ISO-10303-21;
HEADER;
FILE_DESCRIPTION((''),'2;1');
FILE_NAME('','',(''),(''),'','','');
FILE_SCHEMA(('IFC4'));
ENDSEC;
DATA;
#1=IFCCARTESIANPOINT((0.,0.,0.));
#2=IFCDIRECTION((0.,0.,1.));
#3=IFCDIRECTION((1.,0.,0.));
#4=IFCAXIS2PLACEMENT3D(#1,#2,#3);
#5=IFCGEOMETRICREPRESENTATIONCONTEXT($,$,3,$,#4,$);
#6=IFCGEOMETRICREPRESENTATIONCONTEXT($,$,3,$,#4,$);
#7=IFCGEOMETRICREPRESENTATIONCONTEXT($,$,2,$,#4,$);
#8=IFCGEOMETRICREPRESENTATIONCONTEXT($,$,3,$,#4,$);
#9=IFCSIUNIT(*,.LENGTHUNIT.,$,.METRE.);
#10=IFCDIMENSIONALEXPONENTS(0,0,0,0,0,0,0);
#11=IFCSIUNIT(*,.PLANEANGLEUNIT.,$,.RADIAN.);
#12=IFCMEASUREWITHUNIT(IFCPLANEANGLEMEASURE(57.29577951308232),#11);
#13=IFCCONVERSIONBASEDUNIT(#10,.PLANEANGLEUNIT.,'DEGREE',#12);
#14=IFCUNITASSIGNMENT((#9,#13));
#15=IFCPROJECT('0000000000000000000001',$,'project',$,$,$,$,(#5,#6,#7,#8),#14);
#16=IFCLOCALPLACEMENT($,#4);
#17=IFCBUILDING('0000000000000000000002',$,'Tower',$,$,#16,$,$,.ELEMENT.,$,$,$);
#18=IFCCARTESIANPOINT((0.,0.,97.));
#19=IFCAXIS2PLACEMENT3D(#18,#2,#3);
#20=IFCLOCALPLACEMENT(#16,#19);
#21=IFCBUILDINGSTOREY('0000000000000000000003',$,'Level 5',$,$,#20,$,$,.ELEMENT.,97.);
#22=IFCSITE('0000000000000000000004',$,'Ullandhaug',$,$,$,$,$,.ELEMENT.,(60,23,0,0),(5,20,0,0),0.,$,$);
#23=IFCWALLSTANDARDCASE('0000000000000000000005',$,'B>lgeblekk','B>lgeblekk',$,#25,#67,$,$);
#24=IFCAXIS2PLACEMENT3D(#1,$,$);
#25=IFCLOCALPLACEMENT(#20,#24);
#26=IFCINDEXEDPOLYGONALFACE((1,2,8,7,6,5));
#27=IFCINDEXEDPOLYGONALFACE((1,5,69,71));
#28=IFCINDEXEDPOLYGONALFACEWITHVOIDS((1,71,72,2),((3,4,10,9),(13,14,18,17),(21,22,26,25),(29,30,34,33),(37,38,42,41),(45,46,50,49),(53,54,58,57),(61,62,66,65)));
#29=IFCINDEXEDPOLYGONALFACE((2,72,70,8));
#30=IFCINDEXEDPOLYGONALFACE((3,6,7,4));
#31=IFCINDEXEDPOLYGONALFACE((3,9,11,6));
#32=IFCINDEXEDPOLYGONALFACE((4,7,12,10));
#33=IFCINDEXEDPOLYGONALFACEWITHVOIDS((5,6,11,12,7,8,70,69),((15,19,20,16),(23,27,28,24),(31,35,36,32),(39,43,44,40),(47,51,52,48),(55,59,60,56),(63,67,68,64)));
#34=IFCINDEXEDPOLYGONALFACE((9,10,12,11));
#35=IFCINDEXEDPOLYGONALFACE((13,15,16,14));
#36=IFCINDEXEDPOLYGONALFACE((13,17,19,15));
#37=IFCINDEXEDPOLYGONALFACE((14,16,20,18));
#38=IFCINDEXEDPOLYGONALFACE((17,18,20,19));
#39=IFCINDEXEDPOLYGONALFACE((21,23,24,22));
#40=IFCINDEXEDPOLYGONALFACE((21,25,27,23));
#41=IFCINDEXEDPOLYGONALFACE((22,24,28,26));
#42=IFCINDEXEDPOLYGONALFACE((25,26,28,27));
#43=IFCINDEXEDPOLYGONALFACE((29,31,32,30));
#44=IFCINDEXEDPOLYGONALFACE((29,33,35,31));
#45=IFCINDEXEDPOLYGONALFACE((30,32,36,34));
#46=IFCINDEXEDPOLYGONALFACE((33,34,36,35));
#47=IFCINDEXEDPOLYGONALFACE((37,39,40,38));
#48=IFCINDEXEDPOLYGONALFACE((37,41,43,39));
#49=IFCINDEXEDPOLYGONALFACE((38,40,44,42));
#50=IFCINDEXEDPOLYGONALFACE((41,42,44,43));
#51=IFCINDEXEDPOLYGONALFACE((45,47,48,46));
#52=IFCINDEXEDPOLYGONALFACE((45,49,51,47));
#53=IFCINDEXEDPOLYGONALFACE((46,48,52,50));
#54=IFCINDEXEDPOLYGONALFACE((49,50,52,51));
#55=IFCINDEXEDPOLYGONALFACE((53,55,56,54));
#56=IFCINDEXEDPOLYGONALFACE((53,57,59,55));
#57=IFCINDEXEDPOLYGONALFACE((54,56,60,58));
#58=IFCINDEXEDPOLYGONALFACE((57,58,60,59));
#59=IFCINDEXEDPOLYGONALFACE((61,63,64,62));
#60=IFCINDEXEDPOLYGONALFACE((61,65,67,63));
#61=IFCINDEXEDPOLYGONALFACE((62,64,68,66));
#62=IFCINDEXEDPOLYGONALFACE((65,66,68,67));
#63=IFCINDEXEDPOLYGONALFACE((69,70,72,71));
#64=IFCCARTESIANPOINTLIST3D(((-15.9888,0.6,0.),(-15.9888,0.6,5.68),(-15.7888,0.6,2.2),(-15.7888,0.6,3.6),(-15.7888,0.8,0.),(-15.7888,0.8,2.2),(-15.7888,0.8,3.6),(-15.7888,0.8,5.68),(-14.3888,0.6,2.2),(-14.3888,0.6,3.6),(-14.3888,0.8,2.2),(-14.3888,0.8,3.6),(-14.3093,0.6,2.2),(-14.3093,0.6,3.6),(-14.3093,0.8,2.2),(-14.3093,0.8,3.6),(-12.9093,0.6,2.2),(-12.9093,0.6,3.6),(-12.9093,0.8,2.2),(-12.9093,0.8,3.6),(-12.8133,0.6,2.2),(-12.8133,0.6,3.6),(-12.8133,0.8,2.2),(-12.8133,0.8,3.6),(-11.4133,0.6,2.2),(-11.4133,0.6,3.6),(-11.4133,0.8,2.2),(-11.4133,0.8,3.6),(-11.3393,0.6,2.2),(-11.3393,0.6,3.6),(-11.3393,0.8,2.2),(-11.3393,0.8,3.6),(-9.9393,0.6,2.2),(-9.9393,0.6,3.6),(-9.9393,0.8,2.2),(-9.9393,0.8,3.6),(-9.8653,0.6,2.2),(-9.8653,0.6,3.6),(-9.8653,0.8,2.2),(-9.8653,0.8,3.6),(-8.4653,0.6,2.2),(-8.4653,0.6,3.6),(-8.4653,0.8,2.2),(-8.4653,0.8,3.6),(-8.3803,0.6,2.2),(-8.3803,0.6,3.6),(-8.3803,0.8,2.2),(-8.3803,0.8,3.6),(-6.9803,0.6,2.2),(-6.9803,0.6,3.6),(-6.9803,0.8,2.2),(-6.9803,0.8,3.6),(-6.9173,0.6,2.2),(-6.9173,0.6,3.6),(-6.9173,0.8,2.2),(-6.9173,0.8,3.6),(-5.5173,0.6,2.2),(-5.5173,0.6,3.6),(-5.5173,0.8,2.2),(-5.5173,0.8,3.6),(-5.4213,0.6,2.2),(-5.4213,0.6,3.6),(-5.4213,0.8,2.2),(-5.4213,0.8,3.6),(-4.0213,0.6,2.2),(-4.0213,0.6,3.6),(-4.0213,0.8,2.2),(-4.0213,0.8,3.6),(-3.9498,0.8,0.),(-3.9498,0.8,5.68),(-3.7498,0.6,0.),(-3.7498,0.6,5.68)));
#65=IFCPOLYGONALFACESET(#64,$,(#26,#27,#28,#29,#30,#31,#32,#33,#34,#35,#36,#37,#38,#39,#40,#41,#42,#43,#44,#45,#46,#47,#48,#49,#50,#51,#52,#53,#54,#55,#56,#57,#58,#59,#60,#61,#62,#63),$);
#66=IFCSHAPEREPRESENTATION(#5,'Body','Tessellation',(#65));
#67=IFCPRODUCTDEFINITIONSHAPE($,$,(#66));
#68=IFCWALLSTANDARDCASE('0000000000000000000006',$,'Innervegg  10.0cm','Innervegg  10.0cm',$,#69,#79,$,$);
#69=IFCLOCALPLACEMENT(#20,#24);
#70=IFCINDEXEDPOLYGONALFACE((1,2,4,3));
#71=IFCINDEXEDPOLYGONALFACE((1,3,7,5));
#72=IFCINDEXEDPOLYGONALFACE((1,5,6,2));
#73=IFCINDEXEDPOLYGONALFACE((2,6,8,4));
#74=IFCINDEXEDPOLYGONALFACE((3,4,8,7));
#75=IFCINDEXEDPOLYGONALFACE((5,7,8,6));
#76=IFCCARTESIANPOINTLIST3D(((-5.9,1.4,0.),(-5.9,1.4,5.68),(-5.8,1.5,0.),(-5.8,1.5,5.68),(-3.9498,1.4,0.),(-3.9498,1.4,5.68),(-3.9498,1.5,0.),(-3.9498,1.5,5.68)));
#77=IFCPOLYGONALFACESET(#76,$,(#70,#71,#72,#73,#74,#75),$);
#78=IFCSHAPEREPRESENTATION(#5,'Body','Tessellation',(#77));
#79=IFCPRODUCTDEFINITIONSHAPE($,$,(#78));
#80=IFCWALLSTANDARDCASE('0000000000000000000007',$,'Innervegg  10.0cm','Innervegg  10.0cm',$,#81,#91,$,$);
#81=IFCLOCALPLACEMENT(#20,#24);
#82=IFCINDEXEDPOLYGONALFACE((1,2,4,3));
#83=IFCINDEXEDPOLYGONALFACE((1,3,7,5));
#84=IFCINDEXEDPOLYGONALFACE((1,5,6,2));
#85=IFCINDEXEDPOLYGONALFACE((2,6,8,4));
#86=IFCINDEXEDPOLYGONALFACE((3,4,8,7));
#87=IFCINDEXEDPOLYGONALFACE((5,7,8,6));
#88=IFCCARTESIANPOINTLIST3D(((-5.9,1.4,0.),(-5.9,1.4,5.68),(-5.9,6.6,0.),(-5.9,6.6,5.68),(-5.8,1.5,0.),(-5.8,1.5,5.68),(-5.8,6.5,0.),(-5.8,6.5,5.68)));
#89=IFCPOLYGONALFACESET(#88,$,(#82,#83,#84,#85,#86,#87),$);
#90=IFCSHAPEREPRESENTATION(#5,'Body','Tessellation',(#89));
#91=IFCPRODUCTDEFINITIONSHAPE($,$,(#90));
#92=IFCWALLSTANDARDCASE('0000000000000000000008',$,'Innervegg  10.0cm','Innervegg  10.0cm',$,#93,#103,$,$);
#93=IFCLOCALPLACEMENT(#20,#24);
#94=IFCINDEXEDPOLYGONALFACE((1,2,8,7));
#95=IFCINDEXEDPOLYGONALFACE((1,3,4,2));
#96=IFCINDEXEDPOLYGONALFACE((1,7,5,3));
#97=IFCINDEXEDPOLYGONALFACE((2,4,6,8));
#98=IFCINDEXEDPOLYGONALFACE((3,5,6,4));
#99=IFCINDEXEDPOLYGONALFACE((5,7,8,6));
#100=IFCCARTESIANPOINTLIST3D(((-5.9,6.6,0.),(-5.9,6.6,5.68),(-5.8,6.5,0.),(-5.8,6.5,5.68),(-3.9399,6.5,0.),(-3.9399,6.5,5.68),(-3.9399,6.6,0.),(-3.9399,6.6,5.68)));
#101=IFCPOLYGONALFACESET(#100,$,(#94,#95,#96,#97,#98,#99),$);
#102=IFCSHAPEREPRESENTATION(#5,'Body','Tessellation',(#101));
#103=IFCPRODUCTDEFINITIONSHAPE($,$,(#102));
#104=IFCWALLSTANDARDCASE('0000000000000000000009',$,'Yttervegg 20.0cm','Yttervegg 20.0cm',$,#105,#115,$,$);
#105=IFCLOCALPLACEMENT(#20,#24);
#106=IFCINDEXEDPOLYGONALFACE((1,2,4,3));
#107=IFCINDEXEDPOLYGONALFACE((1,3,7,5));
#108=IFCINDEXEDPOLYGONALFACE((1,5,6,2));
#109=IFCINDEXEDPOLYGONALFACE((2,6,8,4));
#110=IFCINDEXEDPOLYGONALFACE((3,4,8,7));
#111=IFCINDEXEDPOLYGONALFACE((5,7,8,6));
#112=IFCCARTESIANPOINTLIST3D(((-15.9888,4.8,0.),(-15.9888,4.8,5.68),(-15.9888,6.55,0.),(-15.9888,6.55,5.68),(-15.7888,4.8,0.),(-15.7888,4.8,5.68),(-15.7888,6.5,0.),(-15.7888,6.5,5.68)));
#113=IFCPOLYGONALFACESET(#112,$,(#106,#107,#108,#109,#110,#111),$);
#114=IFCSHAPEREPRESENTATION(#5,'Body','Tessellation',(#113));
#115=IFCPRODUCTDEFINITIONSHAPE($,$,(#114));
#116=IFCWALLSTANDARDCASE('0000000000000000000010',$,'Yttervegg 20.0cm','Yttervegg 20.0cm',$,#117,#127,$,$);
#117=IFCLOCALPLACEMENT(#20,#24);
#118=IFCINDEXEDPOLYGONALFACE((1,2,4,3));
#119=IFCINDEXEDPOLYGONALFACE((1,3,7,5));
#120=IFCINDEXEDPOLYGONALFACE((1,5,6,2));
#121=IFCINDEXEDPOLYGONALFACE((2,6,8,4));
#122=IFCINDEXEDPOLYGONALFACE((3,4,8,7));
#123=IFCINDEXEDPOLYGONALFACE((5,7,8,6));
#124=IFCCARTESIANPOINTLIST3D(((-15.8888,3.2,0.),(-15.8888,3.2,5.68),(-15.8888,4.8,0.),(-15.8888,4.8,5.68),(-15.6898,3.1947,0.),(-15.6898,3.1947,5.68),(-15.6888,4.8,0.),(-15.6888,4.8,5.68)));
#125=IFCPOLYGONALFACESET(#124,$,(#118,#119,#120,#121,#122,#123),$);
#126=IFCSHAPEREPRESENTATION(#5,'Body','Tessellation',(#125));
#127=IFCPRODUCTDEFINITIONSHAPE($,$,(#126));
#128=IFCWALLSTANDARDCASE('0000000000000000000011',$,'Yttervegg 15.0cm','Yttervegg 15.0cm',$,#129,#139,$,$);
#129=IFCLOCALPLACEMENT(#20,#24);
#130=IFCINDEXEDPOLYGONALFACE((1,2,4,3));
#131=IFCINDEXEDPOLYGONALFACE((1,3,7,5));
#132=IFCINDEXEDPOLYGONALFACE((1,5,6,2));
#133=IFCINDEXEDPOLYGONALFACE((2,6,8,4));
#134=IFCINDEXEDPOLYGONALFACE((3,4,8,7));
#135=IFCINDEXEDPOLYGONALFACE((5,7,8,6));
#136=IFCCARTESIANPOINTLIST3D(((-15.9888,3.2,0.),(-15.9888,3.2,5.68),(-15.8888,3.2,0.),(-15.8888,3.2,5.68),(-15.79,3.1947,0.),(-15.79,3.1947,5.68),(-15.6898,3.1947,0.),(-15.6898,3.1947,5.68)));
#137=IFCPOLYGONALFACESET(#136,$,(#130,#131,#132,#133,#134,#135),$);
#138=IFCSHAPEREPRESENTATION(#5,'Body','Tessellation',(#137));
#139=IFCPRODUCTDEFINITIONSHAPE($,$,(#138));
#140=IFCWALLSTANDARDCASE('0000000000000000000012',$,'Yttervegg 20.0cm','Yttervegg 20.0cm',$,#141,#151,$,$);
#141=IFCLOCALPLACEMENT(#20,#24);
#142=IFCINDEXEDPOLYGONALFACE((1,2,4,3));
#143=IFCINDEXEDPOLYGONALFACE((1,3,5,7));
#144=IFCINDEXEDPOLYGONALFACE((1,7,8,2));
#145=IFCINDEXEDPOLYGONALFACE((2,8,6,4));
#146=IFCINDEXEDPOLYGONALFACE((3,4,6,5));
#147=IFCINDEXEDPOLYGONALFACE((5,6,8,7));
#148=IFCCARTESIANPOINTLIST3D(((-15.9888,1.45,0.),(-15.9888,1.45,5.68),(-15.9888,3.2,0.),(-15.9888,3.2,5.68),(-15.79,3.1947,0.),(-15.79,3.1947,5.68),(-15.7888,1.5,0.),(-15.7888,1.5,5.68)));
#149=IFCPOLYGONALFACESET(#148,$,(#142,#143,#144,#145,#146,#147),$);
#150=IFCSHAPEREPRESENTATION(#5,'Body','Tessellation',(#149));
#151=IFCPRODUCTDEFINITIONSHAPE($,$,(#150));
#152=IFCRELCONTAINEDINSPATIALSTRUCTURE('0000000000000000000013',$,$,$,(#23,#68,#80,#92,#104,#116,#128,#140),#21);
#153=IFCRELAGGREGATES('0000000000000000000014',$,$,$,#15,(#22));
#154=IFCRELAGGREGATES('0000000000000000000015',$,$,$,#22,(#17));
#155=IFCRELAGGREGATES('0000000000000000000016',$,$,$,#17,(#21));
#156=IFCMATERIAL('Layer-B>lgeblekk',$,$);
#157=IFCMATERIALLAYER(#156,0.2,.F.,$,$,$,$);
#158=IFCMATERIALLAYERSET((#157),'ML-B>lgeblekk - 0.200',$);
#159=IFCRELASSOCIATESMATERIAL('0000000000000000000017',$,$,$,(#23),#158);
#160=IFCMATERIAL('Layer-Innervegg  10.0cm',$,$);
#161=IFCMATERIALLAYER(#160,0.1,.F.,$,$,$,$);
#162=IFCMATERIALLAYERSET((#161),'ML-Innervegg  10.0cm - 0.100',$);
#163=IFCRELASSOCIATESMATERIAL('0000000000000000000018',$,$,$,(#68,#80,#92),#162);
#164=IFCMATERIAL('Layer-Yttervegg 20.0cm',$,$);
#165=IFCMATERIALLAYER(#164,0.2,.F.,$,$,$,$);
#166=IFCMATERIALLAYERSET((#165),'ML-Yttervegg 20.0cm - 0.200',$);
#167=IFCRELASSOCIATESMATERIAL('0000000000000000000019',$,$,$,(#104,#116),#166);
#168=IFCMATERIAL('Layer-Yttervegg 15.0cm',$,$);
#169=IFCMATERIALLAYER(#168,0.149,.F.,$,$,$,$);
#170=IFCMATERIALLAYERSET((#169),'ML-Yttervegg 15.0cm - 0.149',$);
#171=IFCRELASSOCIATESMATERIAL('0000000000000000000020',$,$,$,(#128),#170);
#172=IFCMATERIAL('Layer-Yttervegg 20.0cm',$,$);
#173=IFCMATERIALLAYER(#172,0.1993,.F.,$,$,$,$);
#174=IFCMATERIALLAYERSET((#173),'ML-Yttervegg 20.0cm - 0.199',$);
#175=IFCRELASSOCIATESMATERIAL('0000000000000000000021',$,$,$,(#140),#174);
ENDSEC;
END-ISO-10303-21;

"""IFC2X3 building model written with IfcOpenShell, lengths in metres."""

from ifc_helpers import new_model, entity, si_unit, converted_unit, frame, origin_with_axes, place, context, project, spatial, polyline, outline, extrude, material, layer, layer_set, layer_usage, element, save


model = new_model("IFC2X3")

# Units and contexts
context_of_model_1 = context(None, 3, world=origin_with_axes())
context_of_model_2 = context(None, 3, world=origin_with_axes())
context_of_model_3 = context(None, 2, world=origin_with_axes())
context_of_model_4 = context(None, 3, world=origin_with_axes())
ifc_project = project(units=[si_unit("LENGTHUNIT", "METRE"), converted_unit("PLANEANGLEUNIT", "DEGREE", entity("IfcPlaneAngleMeasure", 57.29577951308232), si_unit("PLANEANGLEUNIT", "RADIAN"), dimensions=[0, 0, 0, 0, 0, 0, 0])], contexts=[context_of_model_1, context_of_model_2, context_of_model_3, context_of_model_4])

# Site, building, storey
site = spatial("IfcSite", under=ifc_project, Name="Ullandhaug", CompositionType="ELEMENT", RefLatitude=(60, 23, 0, 0), RefLongitude=(5, 20, 0, 0), RefElevation=0.0)
building_placement = place(None, origin_with_axes())
building = spatial("IfcBuilding", under=site, at=building_placement, Name="Tower", CompositionType="ELEMENT")
storey_placement = place(building_placement, frame((0.0, 0.0, 97.0), z_axis=(0.0, 0.0, 1.0), x_axis=(1.0, 0.0, 0.0)))
storey = spatial("IfcBuildingStorey", under=building, at=storey_placement, Name="Level 5", CompositionType="ELEMENT", Elevation=97.0)

# Shared definitions
ifc_material_1 = material(Name="Layer-Innervegg  10.0cm")
ifc_layer_1 = layer(ifc_material_1, 0.1, ventilated=False)
ifc_layer_set_1 = layer_set([ifc_layer_1], Name="ML-Innervegg  10.0cm - 0.100")
ifc_layer_usage_1 = layer_usage(ifc_layer_set_1, "AXIS2", "POSITIVE", 0.0)

# Wall, openings
ifc_material_2 = material(Name="Layer-B>lgeblekk")
ifc_layer_2 = layer(ifc_material_2, 0.2, ventilated=False)
ifc_layer_set_2 = layer_set([ifc_layer_2], Name="ML-B>lgeblekk - 0.200")
ifc_layer_usage_2 = layer_usage(ifc_layer_set_2, "AXIS2", "POSITIVE", 0.0)
wall_1_placement = place(storey_placement, frame((-15.9888, 0.6, 0.0), z_axis=(0.0, 0.0, 1.0), x_axis=(1.0, 0.0, 0.0)))
wall_1 = element("IfcWallStandardCase", 1, at=wall_1_placement, inside=storey, material=ifc_layer_usage_2, Name="B>lgeblekk", Description="B>lgeblekk", context=context_of_model_1, shape_type="SweptSolid", body=[
    extrude(outline(polyline([(0.0, 0.0), (12.2391, 0.0), (12.0391, 0.2), (0.2, 0.2), (0.0, 0.0)])), origin_with_axes(), (0.0, 0.0, 1.0), 5.68),
])
opening_1_placement = place(wall_1_placement, frame((0.2, 0.2, 2.2), z_axis=(0.0, 0.0, 1.0), x_axis=(1.0, 0.0, 0.0)))
element("IfcOpeningElement", 2, at=opening_1_placement, cuts=wall_1, context=context_of_model_1, shape_type="SweptSolid", body=[
    extrude(outline(polyline([(0.0, 0.0), (1.4, 0.0), (1.4, 1.4), (0.0, 1.4), (0.0, 0.0)])), frame((0.0, 0.0, 0.0), z_axis=(0.0, 1.0, 0.0), x_axis=(0.0, 0.0, 1.0)), (0.0, 0.0, -1.0), 0.2),
])
opening_2_placement = place(wall_1_placement, frame((1.6796, 0.2, 2.2), z_axis=(0.0, 0.0, 1.0), x_axis=(1.0, 0.0, 0.0)))
element("IfcOpeningElement", 3, at=opening_2_placement, cuts=wall_1, context=context_of_model_1, shape_type="SweptSolid", body=[
    extrude(outline(polyline([(0.0, 0.0), (1.4, 0.0), (1.4, 1.4), (0.0, 1.4), (0.0, 0.0)])), frame((0.0, 0.0, 0.0), z_axis=(0.0, 1.0, 0.0), x_axis=(0.0, 0.0, 1.0)), (0.0, 0.0, -1.0), 0.2),
])
opening_3_placement = place(wall_1_placement, frame((3.1756, 0.2, 2.2), z_axis=(0.0, 0.0, 1.0), x_axis=(1.0, 0.0, 0.0)))
element("IfcOpeningElement", 4, at=opening_3_placement, cuts=wall_1, context=context_of_model_1, shape_type="SweptSolid", body=[
    extrude(outline(polyline([(0.0, 0.0), (1.4, 0.0), (1.4, 1.4), (0.0, 1.4), (0.0, 0.0)])), frame((0.0, 0.0, 0.0), z_axis=(0.0, 1.0, 0.0), x_axis=(0.0, 0.0, 1.0)), (0.0, 0.0, -1.0), 0.2),
])
opening_4_placement = place(wall_1_placement, frame((4.6496, 0.2, 2.2), z_axis=(0.0, 0.0, 1.0), x_axis=(1.0, 0.0, 0.0)))
element("IfcOpeningElement", 5, at=opening_4_placement, cuts=wall_1, context=context_of_model_1, shape_type="SweptSolid", body=[
    extrude(outline(polyline([(0.0, 0.0), (1.4, 0.0), (1.4, 1.4), (0.0, 1.4), (0.0, 0.0)])), frame((0.0, 0.0, 0.0), z_axis=(0.0, 1.0, 0.0), x_axis=(0.0, 0.0, 1.0)), (0.0, 0.0, -1.0), 0.2),
])
opening_5_placement = place(wall_1_placement, frame((6.1236, 0.2, 2.2), z_axis=(0.0, 0.0, 1.0), x_axis=(1.0, 0.0, 0.0)))
element("IfcOpeningElement", 6, at=opening_5_placement, cuts=wall_1, context=context_of_model_1, shape_type="SweptSolid", body=[
    extrude(outline(polyline([(0.0, 0.0), (1.4, 0.0), (1.4, 1.4), (0.0, 1.4), (0.0, 0.0)])), frame((0.0, 0.0, 0.0), z_axis=(0.0, 1.0, 0.0), x_axis=(0.0, 0.0, 1.0)), (0.0, 0.0, -1.0), 0.2),
])
opening_6_placement = place(wall_1_placement, frame((7.6086, 0.2, 2.2), z_axis=(0.0, 0.0, 1.0), x_axis=(1.0, 0.0, 0.0)))
element("IfcOpeningElement", 7, at=opening_6_placement, cuts=wall_1, context=context_of_model_1, shape_type="SweptSolid", body=[
    extrude(outline(polyline([(0.0, 0.0), (1.4, 0.0), (1.4, 1.4), (0.0, 1.4), (0.0, 0.0)])), frame((0.0, 0.0, 0.0), z_axis=(0.0, 1.0, 0.0), x_axis=(0.0, 0.0, 1.0)), (0.0, 0.0, -1.0), 0.2),
])
opening_7_placement = place(wall_1_placement, frame((9.0716, 0.2, 2.2), z_axis=(0.0, 0.0, 1.0), x_axis=(1.0, 0.0, 0.0)))
element("IfcOpeningElement", 8, at=opening_7_placement, cuts=wall_1, context=context_of_model_1, shape_type="SweptSolid", body=[
    extrude(outline(polyline([(0.0, 0.0), (1.4, 0.0), (1.4, 1.4), (0.0, 1.4), (0.0, 0.0)])), frame((0.0, 0.0, 0.0), z_axis=(0.0, 1.0, 0.0), x_axis=(0.0, 0.0, 1.0)), (0.0, 0.0, -1.0), 0.2),
])
opening_8_placement = place(wall_1_placement, frame((10.5676, 0.2, 2.2), z_axis=(0.0, 0.0, 1.0), x_axis=(1.0, 0.0, 0.0)))
element("IfcOpeningElement", 9, at=opening_8_placement, cuts=wall_1, context=context_of_model_1, shape_type="SweptSolid", body=[
    extrude(outline(polyline([(0.0, 0.0), (1.4, 0.0), (1.4, 1.4), (0.0, 1.4), (0.0, 0.0)])), frame((0.0, 0.0, 0.0), z_axis=(0.0, 1.0, 0.0), x_axis=(0.0, 0.0, 1.0)), (0.0, 0.0, -1.0), 0.2),
])

# Walls
wall_2_placement = place(storey_placement, frame((-3.9498, 1.5, 0.0), z_axis=(0.0, 0.0, 1.0), x_axis=(-1.0, 0.0, 0.0)))
element("IfcWallStandardCase", 10, at=wall_2_placement, inside=storey, material=ifc_layer_usage_1, Name="Innervegg  10.0cm", Description="Innervegg  10.0cm", context=context_of_model_1, shape_type="SweptSolid", body=[
    extrude(outline(polyline([(0.0, 0.0), (1.8502, 0.0), (1.9502, 0.1), (0.0, 0.1), (0.0, 0.0)])), frame((0.0, 0.0, 0.0), z_axis=(0.0, 0.0, 1.0), x_axis=(1.0, 0.0, 0.0)), (0.0, 0.0, 1.0), 5.68),
])
wall_3_placement = place(storey_placement, frame((-5.8, 1.5, 0.0), z_axis=(0.0, 0.0, 1.0), x_axis=(0.0, 1.0, 0.0)))
element("IfcWallStandardCase", 11, at=wall_3_placement, inside=storey, material=ifc_layer_usage_1, Name="Innervegg  10.0cm", Description="Innervegg  10.0cm", context=context_of_model_1, shape_type="SweptSolid", body=[
    extrude(outline(polyline([(0.0, 0.0), (5.0, 0.0), (5.1, 0.1), (-0.1, 0.1), (0.0, 0.0)])), frame((0.0, 0.0, 0.0), z_axis=(0.0, 0.0, 1.0), x_axis=(1.0, 0.0, 0.0)), (0.0, 0.0, 1.0), 5.68),
])
wall_4_placement = place(storey_placement, frame((-5.8, 6.5, 0.0), z_axis=(0.0, 0.0, 1.0), x_axis=(1.0, 0.0, 0.0)))
element("IfcWallStandardCase", 12, at=wall_4_placement, inside=storey, material=ifc_layer_usage_1, Name="Innervegg  10.0cm", Description="Innervegg  10.0cm", context=context_of_model_1, shape_type="SweptSolid", body=[
    extrude(outline(polyline([(0.0, 0.0), (1.8601, 0.0), (1.8601, 0.1), (-0.1, 0.1), (0.0, 0.0)])), origin_with_axes(), (0.0, 0.0, 1.0), 5.68),
])
ifc_material_3 = material(Name="Layer-Yttervegg 20.0cm")
ifc_layer_3 = layer(ifc_material_3, 0.2, ventilated=False)
ifc_layer_set_3 = layer_set([ifc_layer_3], Name="ML-Yttervegg 20.0cm - 0.200")
ifc_layer_usage_3 = layer_usage(ifc_layer_set_3, "AXIS2", "POSITIVE", 0.0)
wall_5_placement = place(storey_placement, frame((-15.9888, 6.55, 0.0), z_axis=(0.0, 0.0, 1.0), x_axis=(0.0, -1.0, 0.0)))
element("IfcWallStandardCase", 13, at=wall_5_placement, inside=storey, material=ifc_layer_usage_3, Name="Yttervegg 20.0cm", Description="Yttervegg 20.0cm", context=context_of_model_1, shape_type="SweptSolid", body=[
    extrude(outline(polyline([(0.0, 0.0), (1.75, 0.0), (1.75, 0.2), (0.05, 0.2), (0.0, 0.0)])), frame((0.0, 0.0, 0.0), z_axis=(0.0, 0.0, 1.0), x_axis=(1.0, 0.0, 0.0)), (0.0, 0.0, 1.0), 5.68),
])
wall_6_placement = place(storey_placement, frame((-15.8888, 4.8, 0.0), z_axis=(0.0, 0.0, 1.0), x_axis=(0.000001, -1.0, 0.0)))
element("IfcWallStandardCase", 14, at=wall_6_placement, inside=storey, material=ifc_layer_usage_3, Name="Yttervegg 20.0cm", Description="Yttervegg 20.0cm", context=context_of_model_1, shape_type="SweptSolid", body=[
    extrude(outline(polyline([(0.0, 0.0), (1.6, 0.0), (1.6053, 0.199), (0.0, 0.2), (0.0, 0.0)])), frame((0.0, 0.0, 0.0), z_axis=(0.0, 0.0, 1.0), x_axis=(1.0, 0.0, 0.0)), (0.0, 0.0, 1.0), 5.68),
])
ifc_material_4 = material(Name="Layer-Yttervegg 15.0cm")
ifc_layer_4 = layer(ifc_material_4, 0.149, ventilated=False)
ifc_layer_set_4 = layer_set([ifc_layer_4], Name="ML-Yttervegg 15.0cm - 0.149")
ifc_layer_usage_4 = layer_usage(ifc_layer_set_4, "AXIS2", "POSITIVE", 0.0)
wall_7_placement = place(storey_placement, frame((-15.8888, 3.2, 0.0), z_axis=(0.0, 0.0, 1.0), x_axis=(-1.0, 0.0, 0.0)))
element("IfcWallStandardCase", 15, at=wall_7_placement, inside=storey, material=ifc_layer_usage_4, Name="Yttervegg 15.0cm", Description="Yttervegg 15.0cm", context=context_of_model_1, shape_type="SweptSolid", body=[
    extrude(outline(polyline([(0.0, 0.0), (0.1, 0.0), (-0.0989, 0.0053), (-0.199, 0.0053), (0.0, 0.0)])), frame((0.0, 0.0, 0.0), z_axis=(0.0, 0.0, 1.0), x_axis=(1.0, 0.0, 0.0)), (0.0, 0.0, 1.0), 5.68),
])
ifc_material_5 = material(Name="Layer-Yttervegg 20.0cm")
ifc_layer_5 = layer(ifc_material_5, 0.1993, ventilated=False)
ifc_layer_set_5 = layer_set([ifc_layer_5], Name="ML-Yttervegg 20.0cm - 0.199")
ifc_layer_usage_5 = layer_usage(ifc_layer_set_5, "AXIS2", "POSITIVE", 0.0)
wall_8_placement = place(storey_placement, frame((-15.9888, 3.2, 0.0), z_axis=(0.0, 0.0, 1.0), x_axis=(0.0, -1.0, 0.0)))
element("IfcWallStandardCase", 16, at=wall_8_placement, inside=storey, material=ifc_layer_usage_5, Name="Yttervegg 20.0cm", Description="Yttervegg 20.0cm", context=context_of_model_1, shape_type="SweptSolid", body=[
    extrude(outline(polyline([(0.0, 0.0), (1.75, 0.0), (1.7, 0.2), (0.0053, 0.1989), (0.0, 0.0)])), frame((0.0, 0.0, 0.0), z_axis=(0.0, 0.0, 1.0), x_axis=(1.0, 0.0, 0.0)), (0.0, 0.0, 1.0), 5.68),
])

save(model, "model.ifc")
